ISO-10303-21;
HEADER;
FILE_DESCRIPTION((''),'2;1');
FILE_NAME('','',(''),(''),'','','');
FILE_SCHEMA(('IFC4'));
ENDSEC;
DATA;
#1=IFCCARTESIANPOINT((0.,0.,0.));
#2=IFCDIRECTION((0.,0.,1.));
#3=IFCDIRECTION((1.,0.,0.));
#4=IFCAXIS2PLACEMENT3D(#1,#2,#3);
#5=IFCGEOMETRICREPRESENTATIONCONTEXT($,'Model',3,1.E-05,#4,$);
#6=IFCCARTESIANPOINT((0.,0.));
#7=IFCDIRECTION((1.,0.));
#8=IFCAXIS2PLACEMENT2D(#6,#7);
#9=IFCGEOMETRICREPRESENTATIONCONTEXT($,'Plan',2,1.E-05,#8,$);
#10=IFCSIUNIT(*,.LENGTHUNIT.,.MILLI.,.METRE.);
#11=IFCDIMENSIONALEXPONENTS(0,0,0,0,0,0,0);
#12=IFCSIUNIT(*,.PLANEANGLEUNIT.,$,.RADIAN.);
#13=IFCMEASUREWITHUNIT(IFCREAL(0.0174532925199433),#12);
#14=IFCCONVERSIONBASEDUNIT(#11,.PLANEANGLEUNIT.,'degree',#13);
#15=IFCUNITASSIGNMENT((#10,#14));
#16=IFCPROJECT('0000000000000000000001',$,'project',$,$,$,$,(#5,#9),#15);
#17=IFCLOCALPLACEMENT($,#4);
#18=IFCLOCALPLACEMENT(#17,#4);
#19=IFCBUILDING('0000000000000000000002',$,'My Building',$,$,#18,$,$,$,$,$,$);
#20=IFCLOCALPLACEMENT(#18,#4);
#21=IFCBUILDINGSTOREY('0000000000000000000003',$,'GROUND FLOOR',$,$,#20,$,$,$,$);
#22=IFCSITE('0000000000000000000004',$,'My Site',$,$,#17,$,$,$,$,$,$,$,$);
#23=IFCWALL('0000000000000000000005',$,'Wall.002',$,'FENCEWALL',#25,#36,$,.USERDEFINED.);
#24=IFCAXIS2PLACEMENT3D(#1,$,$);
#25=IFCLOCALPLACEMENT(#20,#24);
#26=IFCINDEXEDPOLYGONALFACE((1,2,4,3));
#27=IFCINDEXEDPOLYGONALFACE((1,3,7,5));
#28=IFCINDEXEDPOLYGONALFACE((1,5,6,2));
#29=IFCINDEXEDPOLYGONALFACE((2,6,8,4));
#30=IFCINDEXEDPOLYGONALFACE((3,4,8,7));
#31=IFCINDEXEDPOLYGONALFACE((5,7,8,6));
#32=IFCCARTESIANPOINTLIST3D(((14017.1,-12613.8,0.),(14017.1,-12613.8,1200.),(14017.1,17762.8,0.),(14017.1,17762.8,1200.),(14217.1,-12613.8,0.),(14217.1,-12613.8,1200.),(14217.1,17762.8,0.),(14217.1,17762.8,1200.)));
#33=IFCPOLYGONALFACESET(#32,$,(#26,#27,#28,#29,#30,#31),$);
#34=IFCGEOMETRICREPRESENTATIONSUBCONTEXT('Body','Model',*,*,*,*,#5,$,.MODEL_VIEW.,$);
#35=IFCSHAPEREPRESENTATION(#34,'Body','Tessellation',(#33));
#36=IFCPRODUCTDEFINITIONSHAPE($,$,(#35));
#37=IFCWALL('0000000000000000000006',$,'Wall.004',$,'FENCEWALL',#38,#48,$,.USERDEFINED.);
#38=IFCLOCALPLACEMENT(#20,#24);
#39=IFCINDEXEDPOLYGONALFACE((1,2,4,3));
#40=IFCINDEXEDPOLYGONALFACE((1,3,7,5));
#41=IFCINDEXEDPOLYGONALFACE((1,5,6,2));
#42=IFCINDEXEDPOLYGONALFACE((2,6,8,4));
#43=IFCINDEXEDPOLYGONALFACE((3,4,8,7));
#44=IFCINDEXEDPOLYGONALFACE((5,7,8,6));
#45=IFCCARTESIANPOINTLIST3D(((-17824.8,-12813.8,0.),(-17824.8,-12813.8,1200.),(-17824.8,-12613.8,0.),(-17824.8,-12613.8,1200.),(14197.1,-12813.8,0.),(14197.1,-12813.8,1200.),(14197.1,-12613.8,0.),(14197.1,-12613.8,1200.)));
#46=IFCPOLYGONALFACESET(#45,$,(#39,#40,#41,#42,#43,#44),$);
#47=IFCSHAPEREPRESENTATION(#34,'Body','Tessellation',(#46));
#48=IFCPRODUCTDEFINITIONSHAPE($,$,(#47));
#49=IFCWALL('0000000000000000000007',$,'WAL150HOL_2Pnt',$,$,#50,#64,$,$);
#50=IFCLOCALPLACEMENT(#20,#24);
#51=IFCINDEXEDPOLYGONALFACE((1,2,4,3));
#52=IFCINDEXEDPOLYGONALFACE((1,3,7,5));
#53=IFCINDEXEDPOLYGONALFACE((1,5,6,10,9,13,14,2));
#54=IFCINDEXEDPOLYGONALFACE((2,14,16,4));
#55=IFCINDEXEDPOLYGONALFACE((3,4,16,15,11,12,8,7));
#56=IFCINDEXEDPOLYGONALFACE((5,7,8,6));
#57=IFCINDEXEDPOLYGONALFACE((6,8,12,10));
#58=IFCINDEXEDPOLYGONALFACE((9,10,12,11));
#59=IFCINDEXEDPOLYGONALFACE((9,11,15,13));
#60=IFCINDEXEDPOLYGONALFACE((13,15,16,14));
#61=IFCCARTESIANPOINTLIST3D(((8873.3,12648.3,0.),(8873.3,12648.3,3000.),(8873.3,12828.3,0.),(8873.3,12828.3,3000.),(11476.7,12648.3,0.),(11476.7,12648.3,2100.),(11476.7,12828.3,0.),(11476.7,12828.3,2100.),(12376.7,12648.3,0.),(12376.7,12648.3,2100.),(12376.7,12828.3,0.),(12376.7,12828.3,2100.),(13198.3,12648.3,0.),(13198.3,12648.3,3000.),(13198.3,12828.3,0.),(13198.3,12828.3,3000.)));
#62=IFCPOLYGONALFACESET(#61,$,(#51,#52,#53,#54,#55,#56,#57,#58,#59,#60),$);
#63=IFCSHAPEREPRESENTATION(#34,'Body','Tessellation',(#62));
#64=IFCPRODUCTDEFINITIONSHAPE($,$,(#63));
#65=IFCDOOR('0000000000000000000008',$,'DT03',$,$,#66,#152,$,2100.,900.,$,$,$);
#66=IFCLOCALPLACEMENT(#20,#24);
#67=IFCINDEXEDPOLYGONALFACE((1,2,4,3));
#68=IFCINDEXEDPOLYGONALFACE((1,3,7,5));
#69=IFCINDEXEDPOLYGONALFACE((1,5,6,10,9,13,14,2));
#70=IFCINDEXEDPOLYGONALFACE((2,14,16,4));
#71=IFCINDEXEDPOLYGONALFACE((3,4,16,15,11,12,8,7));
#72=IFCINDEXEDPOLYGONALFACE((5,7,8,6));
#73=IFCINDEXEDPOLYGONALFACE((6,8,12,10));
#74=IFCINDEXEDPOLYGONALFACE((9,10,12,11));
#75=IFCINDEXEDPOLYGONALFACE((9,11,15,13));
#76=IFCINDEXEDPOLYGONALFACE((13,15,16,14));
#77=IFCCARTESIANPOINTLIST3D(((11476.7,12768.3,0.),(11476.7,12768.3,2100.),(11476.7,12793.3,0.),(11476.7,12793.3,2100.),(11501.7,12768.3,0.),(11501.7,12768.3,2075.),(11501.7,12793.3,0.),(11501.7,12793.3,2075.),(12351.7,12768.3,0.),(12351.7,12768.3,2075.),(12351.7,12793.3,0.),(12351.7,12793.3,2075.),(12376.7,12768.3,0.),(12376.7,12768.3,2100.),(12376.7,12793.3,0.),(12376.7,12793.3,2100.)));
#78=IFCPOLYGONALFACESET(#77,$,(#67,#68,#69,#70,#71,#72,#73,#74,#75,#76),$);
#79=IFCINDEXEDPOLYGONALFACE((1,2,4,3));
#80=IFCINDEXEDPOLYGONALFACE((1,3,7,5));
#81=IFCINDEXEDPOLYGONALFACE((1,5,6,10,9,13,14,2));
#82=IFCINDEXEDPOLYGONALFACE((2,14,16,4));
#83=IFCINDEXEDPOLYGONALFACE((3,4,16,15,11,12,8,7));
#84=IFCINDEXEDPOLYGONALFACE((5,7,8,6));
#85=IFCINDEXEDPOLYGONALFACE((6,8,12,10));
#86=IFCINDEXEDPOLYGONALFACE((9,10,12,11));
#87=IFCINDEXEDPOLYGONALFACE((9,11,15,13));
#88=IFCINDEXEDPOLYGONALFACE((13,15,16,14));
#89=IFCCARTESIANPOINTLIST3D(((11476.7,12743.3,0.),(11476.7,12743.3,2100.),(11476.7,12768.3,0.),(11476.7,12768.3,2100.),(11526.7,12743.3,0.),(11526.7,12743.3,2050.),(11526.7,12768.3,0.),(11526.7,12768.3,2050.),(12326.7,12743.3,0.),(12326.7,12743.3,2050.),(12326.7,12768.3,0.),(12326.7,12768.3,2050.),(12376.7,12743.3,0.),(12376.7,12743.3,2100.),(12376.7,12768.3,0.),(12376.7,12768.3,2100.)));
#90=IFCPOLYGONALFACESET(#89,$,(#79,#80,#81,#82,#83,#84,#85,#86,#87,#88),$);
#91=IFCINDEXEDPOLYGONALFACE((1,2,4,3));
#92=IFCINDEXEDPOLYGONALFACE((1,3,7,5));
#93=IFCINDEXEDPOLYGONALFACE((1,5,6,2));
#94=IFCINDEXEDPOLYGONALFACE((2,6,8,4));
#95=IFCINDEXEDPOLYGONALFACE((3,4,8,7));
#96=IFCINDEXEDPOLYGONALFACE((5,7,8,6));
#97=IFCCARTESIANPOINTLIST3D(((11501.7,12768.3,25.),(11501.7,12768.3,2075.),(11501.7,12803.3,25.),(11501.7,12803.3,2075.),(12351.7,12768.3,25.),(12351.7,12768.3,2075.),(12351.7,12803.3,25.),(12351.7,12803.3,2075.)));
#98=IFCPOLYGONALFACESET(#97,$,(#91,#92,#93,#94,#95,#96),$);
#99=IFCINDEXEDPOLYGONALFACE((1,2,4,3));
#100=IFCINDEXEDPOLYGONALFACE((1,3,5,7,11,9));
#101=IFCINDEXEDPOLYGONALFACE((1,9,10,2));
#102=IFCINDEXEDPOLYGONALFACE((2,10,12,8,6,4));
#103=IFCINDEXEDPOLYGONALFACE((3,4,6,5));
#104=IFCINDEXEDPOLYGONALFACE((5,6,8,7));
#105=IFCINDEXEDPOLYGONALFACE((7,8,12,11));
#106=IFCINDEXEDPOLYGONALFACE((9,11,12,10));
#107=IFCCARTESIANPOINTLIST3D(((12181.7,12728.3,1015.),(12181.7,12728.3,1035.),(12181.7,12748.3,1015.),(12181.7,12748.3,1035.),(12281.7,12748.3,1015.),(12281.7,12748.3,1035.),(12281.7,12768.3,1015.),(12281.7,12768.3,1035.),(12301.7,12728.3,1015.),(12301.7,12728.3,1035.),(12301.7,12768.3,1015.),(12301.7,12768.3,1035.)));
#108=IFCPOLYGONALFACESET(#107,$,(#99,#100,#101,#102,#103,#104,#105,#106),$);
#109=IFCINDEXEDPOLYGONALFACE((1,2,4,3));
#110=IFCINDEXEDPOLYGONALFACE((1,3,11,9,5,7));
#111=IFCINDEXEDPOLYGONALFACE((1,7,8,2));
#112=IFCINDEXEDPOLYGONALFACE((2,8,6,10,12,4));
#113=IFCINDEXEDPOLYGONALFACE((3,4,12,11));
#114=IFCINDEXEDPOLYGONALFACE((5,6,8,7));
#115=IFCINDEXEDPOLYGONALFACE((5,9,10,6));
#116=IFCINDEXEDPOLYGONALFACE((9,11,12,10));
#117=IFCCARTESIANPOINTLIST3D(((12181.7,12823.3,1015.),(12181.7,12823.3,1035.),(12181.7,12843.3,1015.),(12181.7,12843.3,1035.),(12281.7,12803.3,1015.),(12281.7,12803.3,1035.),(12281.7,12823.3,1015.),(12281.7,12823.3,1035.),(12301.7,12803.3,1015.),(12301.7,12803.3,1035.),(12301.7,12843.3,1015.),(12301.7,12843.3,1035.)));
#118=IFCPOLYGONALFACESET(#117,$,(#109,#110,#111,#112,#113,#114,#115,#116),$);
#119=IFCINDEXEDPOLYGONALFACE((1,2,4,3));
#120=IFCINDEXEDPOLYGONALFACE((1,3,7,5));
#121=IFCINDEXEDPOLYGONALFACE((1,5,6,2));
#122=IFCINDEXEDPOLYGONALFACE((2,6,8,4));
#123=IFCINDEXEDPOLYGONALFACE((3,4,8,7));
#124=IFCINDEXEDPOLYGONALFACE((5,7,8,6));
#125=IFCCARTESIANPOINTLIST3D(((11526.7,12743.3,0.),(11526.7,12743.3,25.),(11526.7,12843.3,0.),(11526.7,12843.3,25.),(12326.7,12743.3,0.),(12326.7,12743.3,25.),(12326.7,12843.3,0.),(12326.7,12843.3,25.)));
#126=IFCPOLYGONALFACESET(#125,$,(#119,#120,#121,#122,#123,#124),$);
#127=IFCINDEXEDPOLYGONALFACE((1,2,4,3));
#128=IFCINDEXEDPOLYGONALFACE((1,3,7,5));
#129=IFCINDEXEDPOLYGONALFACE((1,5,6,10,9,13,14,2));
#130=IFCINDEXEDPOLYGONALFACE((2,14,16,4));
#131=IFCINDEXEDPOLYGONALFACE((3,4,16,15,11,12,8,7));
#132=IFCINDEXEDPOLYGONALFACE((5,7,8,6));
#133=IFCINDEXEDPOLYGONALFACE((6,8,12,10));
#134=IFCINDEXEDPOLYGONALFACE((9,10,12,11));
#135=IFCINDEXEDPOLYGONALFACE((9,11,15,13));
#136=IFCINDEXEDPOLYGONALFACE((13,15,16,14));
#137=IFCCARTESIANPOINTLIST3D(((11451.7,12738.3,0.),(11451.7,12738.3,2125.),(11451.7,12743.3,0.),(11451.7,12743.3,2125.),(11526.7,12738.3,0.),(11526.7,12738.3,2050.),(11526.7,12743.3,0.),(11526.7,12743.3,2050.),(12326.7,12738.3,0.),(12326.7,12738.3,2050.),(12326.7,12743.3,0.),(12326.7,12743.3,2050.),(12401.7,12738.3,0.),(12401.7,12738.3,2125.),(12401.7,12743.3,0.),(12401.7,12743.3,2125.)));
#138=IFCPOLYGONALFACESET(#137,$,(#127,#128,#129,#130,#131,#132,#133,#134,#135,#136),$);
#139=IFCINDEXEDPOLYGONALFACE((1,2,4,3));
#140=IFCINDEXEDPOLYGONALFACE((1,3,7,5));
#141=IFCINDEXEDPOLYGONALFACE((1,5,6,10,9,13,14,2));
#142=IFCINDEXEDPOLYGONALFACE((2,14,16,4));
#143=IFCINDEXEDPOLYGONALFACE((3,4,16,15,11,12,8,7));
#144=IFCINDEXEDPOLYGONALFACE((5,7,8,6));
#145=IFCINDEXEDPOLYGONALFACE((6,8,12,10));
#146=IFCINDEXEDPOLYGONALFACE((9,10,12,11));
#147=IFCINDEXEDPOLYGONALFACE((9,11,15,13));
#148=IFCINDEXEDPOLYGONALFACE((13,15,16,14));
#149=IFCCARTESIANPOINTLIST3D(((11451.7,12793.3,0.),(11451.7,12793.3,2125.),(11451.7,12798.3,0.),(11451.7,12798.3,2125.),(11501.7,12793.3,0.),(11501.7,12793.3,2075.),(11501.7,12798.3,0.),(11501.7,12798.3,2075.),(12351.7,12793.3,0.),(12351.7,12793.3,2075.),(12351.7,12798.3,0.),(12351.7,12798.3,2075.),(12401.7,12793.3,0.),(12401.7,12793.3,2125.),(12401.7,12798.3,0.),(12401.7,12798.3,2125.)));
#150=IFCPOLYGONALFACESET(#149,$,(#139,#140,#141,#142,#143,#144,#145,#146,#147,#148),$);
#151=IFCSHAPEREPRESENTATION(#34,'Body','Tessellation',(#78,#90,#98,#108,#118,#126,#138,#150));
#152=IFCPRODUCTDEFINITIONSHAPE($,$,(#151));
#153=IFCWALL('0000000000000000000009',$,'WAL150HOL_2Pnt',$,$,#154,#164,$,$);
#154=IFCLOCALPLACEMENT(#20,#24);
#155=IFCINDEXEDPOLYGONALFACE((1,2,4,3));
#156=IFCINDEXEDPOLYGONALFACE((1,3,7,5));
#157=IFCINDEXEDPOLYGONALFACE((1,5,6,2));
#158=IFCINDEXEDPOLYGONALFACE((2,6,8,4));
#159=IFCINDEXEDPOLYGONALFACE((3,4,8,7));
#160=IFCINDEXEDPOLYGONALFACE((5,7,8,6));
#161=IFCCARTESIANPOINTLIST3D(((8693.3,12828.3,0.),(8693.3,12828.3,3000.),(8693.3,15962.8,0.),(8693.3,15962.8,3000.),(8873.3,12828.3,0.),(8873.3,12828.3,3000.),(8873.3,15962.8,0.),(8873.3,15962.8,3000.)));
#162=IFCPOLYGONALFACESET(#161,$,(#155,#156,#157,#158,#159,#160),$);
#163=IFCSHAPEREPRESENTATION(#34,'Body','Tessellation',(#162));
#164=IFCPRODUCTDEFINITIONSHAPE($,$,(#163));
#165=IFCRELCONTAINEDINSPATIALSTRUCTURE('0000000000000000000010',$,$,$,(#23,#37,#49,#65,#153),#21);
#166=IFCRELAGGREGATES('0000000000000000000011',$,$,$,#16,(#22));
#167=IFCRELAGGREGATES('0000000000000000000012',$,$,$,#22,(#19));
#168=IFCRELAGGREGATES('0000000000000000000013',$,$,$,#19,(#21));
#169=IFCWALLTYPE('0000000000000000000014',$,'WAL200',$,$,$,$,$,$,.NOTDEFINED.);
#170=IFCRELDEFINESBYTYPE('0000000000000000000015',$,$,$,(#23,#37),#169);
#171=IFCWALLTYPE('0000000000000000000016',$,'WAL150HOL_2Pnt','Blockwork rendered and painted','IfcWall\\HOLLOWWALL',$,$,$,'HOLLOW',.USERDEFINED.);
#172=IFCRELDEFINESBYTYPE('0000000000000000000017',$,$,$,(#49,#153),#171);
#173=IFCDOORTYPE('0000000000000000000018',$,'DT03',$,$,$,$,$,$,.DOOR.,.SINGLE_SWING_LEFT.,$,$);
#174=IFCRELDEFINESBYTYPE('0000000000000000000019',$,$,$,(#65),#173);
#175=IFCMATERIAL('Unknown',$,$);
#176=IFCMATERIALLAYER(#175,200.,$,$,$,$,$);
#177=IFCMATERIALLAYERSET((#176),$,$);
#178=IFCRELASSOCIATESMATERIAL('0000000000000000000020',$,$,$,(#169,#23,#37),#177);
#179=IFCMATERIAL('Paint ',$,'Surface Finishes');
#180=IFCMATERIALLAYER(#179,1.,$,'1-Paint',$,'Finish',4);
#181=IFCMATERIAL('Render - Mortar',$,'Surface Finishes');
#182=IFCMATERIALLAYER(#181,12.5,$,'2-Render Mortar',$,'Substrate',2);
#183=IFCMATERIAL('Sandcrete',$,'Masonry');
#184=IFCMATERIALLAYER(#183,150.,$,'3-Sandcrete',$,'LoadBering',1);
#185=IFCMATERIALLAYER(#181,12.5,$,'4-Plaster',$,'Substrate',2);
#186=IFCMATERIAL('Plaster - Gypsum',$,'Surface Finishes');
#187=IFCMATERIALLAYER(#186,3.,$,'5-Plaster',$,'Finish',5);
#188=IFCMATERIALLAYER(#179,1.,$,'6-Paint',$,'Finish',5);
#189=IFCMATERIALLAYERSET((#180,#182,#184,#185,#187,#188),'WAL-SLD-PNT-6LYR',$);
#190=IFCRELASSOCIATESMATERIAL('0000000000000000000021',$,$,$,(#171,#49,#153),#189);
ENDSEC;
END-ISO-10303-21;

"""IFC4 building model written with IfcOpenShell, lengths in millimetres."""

from ifc_helpers import new_model, entity, si_unit, converted_unit, frame, origin_with_axes, origin_2d_with_axis, place, context, subcontext, project, spatial, line, indexed_curve, outline, extrude, shape, source, transform, mapped, material, layer, layer_set, layer_usage, type_object, type_shapes, element, fill, save


model = new_model("IFC4")

# Units and contexts
model_context = context("Model", 3, precision=1e-05, world=origin_with_axes())
plan_context = context("Plan", 2, precision=1e-05, world=origin_2d_with_axis())
body_context_1 = subcontext(model_context, "Body", "Model", "MODEL_VIEW")
body_context_2 = subcontext(plan_context, "Body", "Plan", "PLAN_VIEW")
ifc_project = project(units=[si_unit("LENGTHUNIT", "METRE", prefix="MILLI"), converted_unit("PLANEANGLEUNIT", "degree", entity("IfcReal", 0.0174532925199433), si_unit("PLANEANGLEUNIT", "RADIAN"), dimensions=[0, 0, 0, 0, 0, 0, 0])], contexts=[model_context, plan_context])

# Site, building, storey
site_placement = place(None, origin_with_axes())
site = spatial("IfcSite", under=ifc_project, at=site_placement, Name="My Site")
building_placement = place(site_placement, origin_with_axes())
building = spatial("IfcBuilding", under=site, at=building_placement, Name="My Building")
storey_placement = place(building_placement, origin_with_axes())
storey = spatial("IfcBuildingStorey", under=building, at=storey_placement, Name="GROUND FLOOR")

# Walls
ifc_material_1 = material(Name="Unknown")
ifc_layer_1 = layer(ifc_material_1, 200.0)
ifc_layer_set_1 = layer_set([ifc_layer_1])
ifc_layer_usage_1 = layer_usage(ifc_layer_set_1, "AXIS2", "POSITIVE", 0.0)
wall_type_1 = type_object("IfcWallType", Name="WAL200", PredefinedType="NOTDEFINED", material=ifc_layer_set_1)
wall_1_placement = place(storey_placement, frame((14017.1, 17762.8, 0.0), z_axis=(0.0, 0.0, 1.0), x_axis=(-0.000001, -1.0, 0.0)))
element("IfcWall", 1, at=wall_1_placement, inside=storey, type_object=wall_type_1, material=ifc_layer_usage_1, Name="Wall.002", ObjectType="FENCEWALL", PredefinedType="USERDEFINED", context=body_context_1, shape_type="SweptSolid", body=[
    extrude(outline(indexed_curve([(0.0, 0.0), (0.0, 200.0), (30376.6, 200.0), (30376.6, 0.0), (0.0, 0.0)], self_intersect=False)), origin_with_axes(), (0.0, 0.0, 1.0), 1200.0),
])
ifc_layer_usage_2 = layer_usage(ifc_layer_set_1, "AXIS2", "POSITIVE", 0.0)
wall_2_placement = place(storey_placement, frame((14197.1, -12613.8, 0.0), z_axis=(0.0, 0.0, 1.0), x_axis=(-1.0, 0.0, 0.0)))
element("IfcWall", 2, at=wall_2_placement, inside=storey, type_object=wall_type_1, material=ifc_layer_usage_2, Name="Wall.004", ObjectType="FENCEWALL", PredefinedType="USERDEFINED", context=body_context_1, shape_type="SweptSolid", body=[
    extrude(outline(indexed_curve([(0.0, 0.0), (0.0, 200.0), (32021.9, 200.0), (32021.9, 0.0), (0.0, 0.0)], self_intersect=False)), origin_with_axes(), (0.0, 0.0, 1.0), 1200.0),
])

# Wall, opening, door
ifc_material_2 = material(Name="Paint ", Category="Surface Finishes")
ifc_layer_2 = layer(ifc_material_2, 1.0, Name="1-Paint", Category="Finish", Priority=4)
ifc_material_3 = material(Name="Render - Mortar", Category="Surface Finishes")
ifc_layer_3 = layer(ifc_material_3, 12.5, Name="2-Render Mortar", Category="Substrate", Priority=2)
ifc_material_4 = material(Name="Sandcrete", Category="Masonry")
ifc_layer_4 = layer(ifc_material_4, 150.0, Name="3-Sandcrete", Category="LoadBering", Priority=1)
ifc_layer_5 = layer(ifc_material_3, 12.5, Name="4-Plaster", Category="Substrate", Priority=2)
ifc_material_5 = material(Name="Plaster - Gypsum", Category="Surface Finishes")
ifc_layer_6 = layer(ifc_material_5, 3.0, Name="5-Plaster", Category="Finish", Priority=5)
ifc_layer_7 = layer(ifc_material_2, 1.0, Name="6-Paint", Category="Finish", Priority=5)
ifc_layer_set_2 = layer_set([ifc_layer_2, ifc_layer_3, ifc_layer_4, ifc_layer_5, ifc_layer_6, ifc_layer_7], Name="WAL-SLD-PNT-6LYR")
ifc_layer_usage_3 = layer_usage(ifc_layer_set_2, "AXIS2", "POSITIVE", 0.0)
wall_type_2 = type_object("IfcWallType", Name="WAL150HOL_2Pnt", Description="Blockwork rendered and painted", ApplicableOccurrence="IfcWall\\HOLLOWWALL", ElementType="HOLLOW", PredefinedType="USERDEFINED", material=ifc_layer_set_2)
wall_3_placement = place(storey_placement, frame((13198.3, 12828.3, 0.0), z_axis=(0.0, 0.0, 1.0), x_axis=(-1.0, 0.000001, 0.0)))
wall_3 = element("IfcWall", 3, at=wall_3_placement, inside=storey, type_object=wall_type_2, material=ifc_layer_usage_3, Name="WAL150HOL_2Pnt", context=body_context_1, shape_type="SweptSolid", body=[
    extrude(outline(indexed_curve([(0.0, 0.0), (0.0, 180.0), (4325.0, 180.0), (4325.0, 0.0), (0.0, 0.0)], self_intersect=False)), origin_with_axes(), (0.0, 0.0, 1.0), 3000.0),
])
shared_shape_1 = source(origin_with_axes(), body_context_1, "Body", "SweptSolid", [
    extrude(outline(indexed_curve([(0.0, 0.0), (900.0, 0.0), (900.0, 2100.0), (0.0, 2100.0)], segments=[line(1, 2, 3, 4, 1)])), frame((0.0, -100.0, 0.0), z_axis=(0.0, -1.0, 0.0), x_axis=(1.0, 0.0, 0.0)), (0.0, 0.0, -1.0), 380.0),
])
opening_1_placement = place(wall_3_placement, frame((821.6, 0.0, 0.0), z_axis=(0.0, 0.0, 1.0), x_axis=(1.0, 0.0, 0.0)))
opening_1 = element("IfcOpeningElement", 4, at=opening_1_placement, cuts=wall_3, PredefinedType="OPENING", context=body_context_1, shape_type="MappedRepresentation", body=[
    mapped(shared_shape_1, transform((0.0, 0.0, 0.0), x_axis=(1.0, 0.0, 0.0), y_axis=(0.0, 1.0, 0.0), z_axis=(0.0, 0.0, 1.0), scale=1.0)),
])
door_type_1 = type_object("IfcDoorType", Name="DT03", OperationType="SINGLE_SWING_LEFT", PredefinedType="DOOR")
shared_shape_2 = source(origin_with_axes(), body_context_1, "Body", "SweptSolid", [
    extrude(outline(indexed_curve([(0.0, 0.0), (0.0, 2100.0), (900.0, 2100.0), (900.0, 0.0), (875.0, 0.0), (875.0, 2075.0), (25.0, 2075.0), (25.0, 0.0)], segments=[line(1, 2, 3, 4, 5, 6, 7, 8, 1)])), frame((0.0, 25.0, 0.0), z_axis=(0.0, -1.0, 0.0), x_axis=(1.0, 0.0, 0.0)), (0.0, 0.0, -1.0), 25.0),
    extrude(outline(indexed_curve([(0.0, 0.0), (0.0, 2100.0), (900.0, 2100.0), (900.0, 0.0), (850.0, 0.0), (850.0, 2050.0), (50.0, 2050.0), (50.0, 0.0)], segments=[line(1, 2, 3, 4, 5, 6, 7, 8, 1)])), frame((0.0, 0.0, 0.0), z_axis=(0.0, -1.0, 0.0), x_axis=(1.0, 0.0, 0.0)), (0.0, 0.0, -1.0), 25.0),
    extrude(outline(indexed_curve([(0.0, 0.0), (850.0, 0.0), (850.0, 35.0), (0.0, 35.0)], segments=[line(1, 2, 3, 4, 1)])), frame((25.0, 25.0, 25.0), z_axis=(0.0, 0.0, 1.0), x_axis=(1.0, 0.0, 0.0)), (0.0, 0.0, 1.0), 2050.0),
    extrude(outline(indexed_curve([(0.0, 0.0), (0.0, -40.0), (-120.0, -40.0), (-120.0, -20.0), (-20.0, -20.0), (-20.0, 0.0)], segments=[line(1, 2, 3, 4, 5, 6, 1)])), frame((825.0, 25.0, 1015.0), z_axis=(0.0, 0.0, 1.0), x_axis=(1.0, 0.0, 0.0)), (0.0, 0.0, 1.0), 20.0),
    extrude(outline(indexed_curve([(0.0, 0.0), (0.0, 40.0), (-120.0, 40.0), (-120.0, 20.0), (-20.0, 20.0), (-20.0, 0.0)], segments=[line(1, 2, 3, 4, 5, 6, 1)])), frame((825.0, 60.0, 1015.0), z_axis=(0.0, 0.0, 1.0), x_axis=(1.0, 0.0, 0.0)), (0.0, 0.0, 1.0), 20.0),
    extrude(outline(indexed_curve([(0.0, 0.0), (800.0, 0.0), (800.0, 100.0), (0.0, 100.0)], segments=[line(1, 2, 3, 4, 1)])), frame((50.0, 0.0, 0.0), z_axis=(0.0, 0.0, 1.0), x_axis=(1.0, 0.0, 0.0)), (0.0, 0.0, 1.0), 25.0),
    extrude(outline(indexed_curve([(0.0, 0.0), (0.0, 2125.0), (950.0, 2125.0), (950.0, 0.0), (875.0, 0.0), (875.0, 2050.0), (75.0, 2050.0), (75.0, 0.0)], segments=[line(1, 2, 3, 4, 5, 6, 7, 8, 1)])), frame((-25.0, -5.0, 0.0), z_axis=(0.0, -1.0, 0.0), x_axis=(1.0, 0.0, 0.0)), (0.0, 0.0, -1.0), 5.0),
    extrude(outline(indexed_curve([(0.0, 0.0), (0.0, 2125.0), (950.0, 2125.0), (950.0, 0.0), (900.0, 0.0), (900.0, 2075.0), (50.0, 2075.0), (50.0, 0.0)], segments=[line(1, 2, 3, 4, 5, 6, 7, 8, 1)])), frame((-25.0, 50.0, 0.0), z_axis=(0.0, -1.0, 0.0), x_axis=(1.0, 0.0, 0.0)), (0.0, 0.0, -1.0), 5.0),
])
shared_shape_3 = source(origin_with_axes(), body_context_2, "Body", "Curve2D", [
    entity("IfcIndexedPolyCurve", entity("IfcCartesianPointList2D", [[0.0, 0.0], [0.0, 50.0], [25.0, 50.0], [25.0, 25.0], [50.0, 25.0], [50.0, 0.0]]), [entity("IfcLineIndex", [1, 2, 3, 4, 5, 6, 1])]),
    entity("IfcIndexedPolyCurve", entity("IfcCartesianPointList2D", [[900.0, 0.0], [900.0, 50.0], [875.0, 50.0], [875.0, 25.0], [850.0, 25.0], [850.0, 0.0]]), [entity("IfcLineIndex", [1, 2, 3, 4, 5, 6, 1])]),
    entity("IfcTrimmedCurve", entity("IfcEllipse", entity("IfcAxis2Placement2D", entity("IfcCartesianPoint", [60.0, 50.0]), entity("IfcDirection", [1.0, 0.0])), 815.0, 850.0), [entity("IfcCartesianPoint", [875.0, 50.0])], [entity("IfcCartesianPoint", [60.0, 900.0])], True, "CARTESIAN"),
    entity("IfcIndexedPolyCurve", entity("IfcCartesianPointList2D", [[25.0, 50.0], [60.0, 50.0], [60.0, 900.0], [25.0, 900.0]]), [entity("IfcLineIndex", [1, 2, 3, 4, 1])]),
])
type_shapes(door_type_1, [shared_shape_2, shared_shape_3])
door_1_placement = place(opening_1_placement, frame((900.0, 85.0, 0.0), z_axis=(0.0, 0.0, 1.0), x_axis=(-1.0, 0.0, 0.0)))
door_1 = element("IfcDoor", 5, at=door_1_placement, inside=storey, type_object=door_type_1, Name="DT03", OverallHeight=2100.0, OverallWidth=900.0, shapes=[
    shape(body_context_1, "Body", "MappedRepresentation", [mapped(shared_shape_2, transform((0.0, 0.0, 0.0), x_axis=(1.0, 0.0, 0.0), y_axis=(0.0, 1.0, 0.0), z_axis=(0.0, 0.0, 1.0), scale=1.0))]),
    shape(body_context_2, "Body", "MappedRepresentation", [mapped(shared_shape_3, transform((0.0, 0.0, 0.0), x_axis=(1.0, 0.0, 0.0), y_axis=(0.0, 1.0, 0.0), z_axis=(0.0, 0.0, 1.0), scale=1.0))]),
])
fill(opening_1, door_1)

# Wall
ifc_layer_usage_4 = layer_usage(ifc_layer_set_2, "AXIS2", "POSITIVE", 0.0)
wall_4_placement = place(storey_placement, frame((8873.3, 12828.3, 0.0), z_axis=(0.0, 0.0, 1.0), x_axis=(0.000001, 1.0, 0.0)))
element("IfcWall", 6, at=wall_4_placement, inside=storey, type_object=wall_type_2, material=ifc_layer_usage_4, Name="WAL150HOL_2Pnt", context=body_context_1, shape_type="SweptSolid", body=[
    extrude(outline(indexed_curve([(0.0, 0.0), (0.0, 180.0), (3134.5, 180.0), (3134.5, 0.0), (0.0, 0.0)], self_intersect=False)), origin_with_axes(), (0.0, 0.0, 1.0), 3000.0),
])

save(model, "model.ifc")
